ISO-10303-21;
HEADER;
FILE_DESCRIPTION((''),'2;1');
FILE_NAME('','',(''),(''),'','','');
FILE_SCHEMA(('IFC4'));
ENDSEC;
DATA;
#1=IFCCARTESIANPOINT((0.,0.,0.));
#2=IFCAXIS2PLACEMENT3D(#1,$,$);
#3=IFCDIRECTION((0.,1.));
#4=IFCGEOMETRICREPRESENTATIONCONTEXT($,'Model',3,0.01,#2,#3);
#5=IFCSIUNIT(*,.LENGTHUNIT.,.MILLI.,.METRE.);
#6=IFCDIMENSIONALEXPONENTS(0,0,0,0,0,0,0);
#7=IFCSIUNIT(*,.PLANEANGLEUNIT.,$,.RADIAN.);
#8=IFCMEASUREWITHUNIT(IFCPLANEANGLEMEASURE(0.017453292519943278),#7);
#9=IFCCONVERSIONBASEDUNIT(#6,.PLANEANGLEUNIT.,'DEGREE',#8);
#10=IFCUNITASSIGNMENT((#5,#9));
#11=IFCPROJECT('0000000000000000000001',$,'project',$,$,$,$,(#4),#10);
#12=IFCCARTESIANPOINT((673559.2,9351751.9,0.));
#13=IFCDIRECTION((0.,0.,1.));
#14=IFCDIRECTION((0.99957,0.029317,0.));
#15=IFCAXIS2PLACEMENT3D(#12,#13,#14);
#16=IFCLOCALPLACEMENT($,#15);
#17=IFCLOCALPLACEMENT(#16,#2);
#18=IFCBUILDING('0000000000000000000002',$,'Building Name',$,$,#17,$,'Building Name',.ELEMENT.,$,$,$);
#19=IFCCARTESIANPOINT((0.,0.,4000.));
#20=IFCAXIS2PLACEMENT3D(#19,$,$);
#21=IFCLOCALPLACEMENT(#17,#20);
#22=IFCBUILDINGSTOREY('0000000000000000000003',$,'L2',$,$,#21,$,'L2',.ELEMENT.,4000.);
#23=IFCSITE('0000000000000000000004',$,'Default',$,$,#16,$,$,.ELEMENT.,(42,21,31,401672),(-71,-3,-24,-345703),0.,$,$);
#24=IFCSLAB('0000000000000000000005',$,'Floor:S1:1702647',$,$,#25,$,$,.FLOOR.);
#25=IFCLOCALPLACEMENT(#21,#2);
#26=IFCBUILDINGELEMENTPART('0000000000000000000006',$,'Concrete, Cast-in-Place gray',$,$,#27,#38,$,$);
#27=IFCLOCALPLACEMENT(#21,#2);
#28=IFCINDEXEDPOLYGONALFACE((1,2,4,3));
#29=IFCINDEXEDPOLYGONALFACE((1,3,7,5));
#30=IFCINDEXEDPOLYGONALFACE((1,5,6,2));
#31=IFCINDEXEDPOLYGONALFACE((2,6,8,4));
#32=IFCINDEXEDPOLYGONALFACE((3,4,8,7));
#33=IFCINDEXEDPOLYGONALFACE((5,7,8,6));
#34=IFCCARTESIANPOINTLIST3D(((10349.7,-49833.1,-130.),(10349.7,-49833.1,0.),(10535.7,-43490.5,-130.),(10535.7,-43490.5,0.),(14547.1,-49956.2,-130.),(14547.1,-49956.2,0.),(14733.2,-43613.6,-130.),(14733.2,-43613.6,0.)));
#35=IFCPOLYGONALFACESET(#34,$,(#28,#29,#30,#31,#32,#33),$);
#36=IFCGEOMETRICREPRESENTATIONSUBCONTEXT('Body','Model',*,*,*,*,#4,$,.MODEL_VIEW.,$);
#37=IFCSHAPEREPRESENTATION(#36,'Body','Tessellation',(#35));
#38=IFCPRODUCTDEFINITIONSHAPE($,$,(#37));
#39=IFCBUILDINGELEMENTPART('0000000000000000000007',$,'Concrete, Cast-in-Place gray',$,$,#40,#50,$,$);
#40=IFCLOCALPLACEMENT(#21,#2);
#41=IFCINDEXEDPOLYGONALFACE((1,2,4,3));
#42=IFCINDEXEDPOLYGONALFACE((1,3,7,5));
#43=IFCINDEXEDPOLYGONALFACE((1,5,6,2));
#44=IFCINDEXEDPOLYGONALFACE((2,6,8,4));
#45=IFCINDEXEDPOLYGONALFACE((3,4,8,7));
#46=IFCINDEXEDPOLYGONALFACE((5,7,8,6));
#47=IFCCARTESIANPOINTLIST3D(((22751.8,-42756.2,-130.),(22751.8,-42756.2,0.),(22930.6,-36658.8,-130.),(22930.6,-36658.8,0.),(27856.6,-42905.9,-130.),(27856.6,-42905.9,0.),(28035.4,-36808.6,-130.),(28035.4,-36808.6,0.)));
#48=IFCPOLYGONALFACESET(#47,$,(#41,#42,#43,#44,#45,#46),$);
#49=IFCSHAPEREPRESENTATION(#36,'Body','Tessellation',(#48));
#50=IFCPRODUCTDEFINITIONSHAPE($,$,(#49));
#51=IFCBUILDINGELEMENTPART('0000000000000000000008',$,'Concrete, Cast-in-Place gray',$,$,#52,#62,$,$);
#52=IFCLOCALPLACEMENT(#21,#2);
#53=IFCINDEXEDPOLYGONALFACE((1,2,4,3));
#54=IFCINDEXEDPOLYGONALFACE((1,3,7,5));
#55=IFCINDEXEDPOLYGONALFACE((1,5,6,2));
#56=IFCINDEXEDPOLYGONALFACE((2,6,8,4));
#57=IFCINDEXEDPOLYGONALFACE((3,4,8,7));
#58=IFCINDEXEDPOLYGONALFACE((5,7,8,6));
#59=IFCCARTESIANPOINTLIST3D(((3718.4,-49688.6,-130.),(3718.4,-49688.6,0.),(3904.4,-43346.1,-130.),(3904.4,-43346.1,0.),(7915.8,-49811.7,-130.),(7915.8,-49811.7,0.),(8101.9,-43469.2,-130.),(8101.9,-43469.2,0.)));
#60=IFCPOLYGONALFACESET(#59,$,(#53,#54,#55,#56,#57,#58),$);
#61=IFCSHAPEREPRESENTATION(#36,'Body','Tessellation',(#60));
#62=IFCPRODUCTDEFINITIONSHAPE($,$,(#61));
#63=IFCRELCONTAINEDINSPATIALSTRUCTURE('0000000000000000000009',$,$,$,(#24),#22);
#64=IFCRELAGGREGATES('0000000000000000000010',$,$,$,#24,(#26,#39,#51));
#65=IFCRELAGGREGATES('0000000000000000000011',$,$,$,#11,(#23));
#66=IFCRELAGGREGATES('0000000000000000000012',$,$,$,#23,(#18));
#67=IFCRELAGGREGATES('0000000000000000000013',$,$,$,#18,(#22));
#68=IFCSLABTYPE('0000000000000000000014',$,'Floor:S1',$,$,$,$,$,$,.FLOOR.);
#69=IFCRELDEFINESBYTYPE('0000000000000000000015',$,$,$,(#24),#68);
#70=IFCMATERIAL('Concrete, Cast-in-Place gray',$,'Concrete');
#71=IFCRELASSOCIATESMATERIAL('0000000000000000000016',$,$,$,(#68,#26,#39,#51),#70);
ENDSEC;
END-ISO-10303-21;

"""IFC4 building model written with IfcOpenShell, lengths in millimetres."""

from ifc_helpers import new_model, entity, si_unit, converted_unit, direction, frame, origin, place, context, subcontext, project, spatial, indexed_curve, outline, extrude, material, type_object, element, aggregate, save


model = new_model("IFC4")

# Units and contexts
model_context = context("Model", 3, precision=0.01, world=origin(), true_north=direction((0.0, 1.0)))
body_context = subcontext(model_context, "Body", "Model", "MODEL_VIEW")
ifc_project = project(units=[si_unit("LENGTHUNIT", "METRE", prefix="MILLI"), converted_unit("PLANEANGLEUNIT", "DEGREE", entity("IfcPlaneAngleMeasure", 0.017453292519943278), si_unit("PLANEANGLEUNIT", "RADIAN"), dimensions=[0, 0, 0, 0, 0, 0, 0])], contexts=[model_context])

# Site, building, storey
site_placement = place(None, frame((673559.2, 9351751.9, 0.0), z_axis=(0.0, 0.0, 1.0), x_axis=(0.99957, 0.029317, 0.0)))
site = spatial("IfcSite", under=ifc_project, at=site_placement, Name="Default", CompositionType="ELEMENT", RefLatitude=(42, 21, 31, 401672), RefLongitude=(-71, -3, -24, -345703), RefElevation=0.0)
building_placement = place(site_placement, origin())
building = spatial("IfcBuilding", under=site, at=building_placement, Name="Building Name", LongName="Building Name", CompositionType="ELEMENT")
storey_placement = place(building_placement, frame((0.0, 0.0, 4000.0)))
storey = spatial("IfcBuildingStorey", under=building, at=storey_placement, Name="L2", LongName="L2", CompositionType="ELEMENT", Elevation=4000.0)

# Shared definitions
ifc_material = material(Name="Concrete, Cast-in-Place gray", Category="Concrete")
slab_type_1 = type_object("IfcSlabType", Name="Floor:S1", PredefinedType="FLOOR", material=ifc_material)

# Slab, building element parts
slab_1_placement = place(storey_placement, origin())
slab_1 = element("IfcSlab", 1, at=slab_1_placement, inside=storey, type_object=slab_type_1, Name="Floor:S1:1702647", PredefinedType="FLOOR")
building_element_part_1_placement = place(slab_1_placement, origin())
building_element_part_1 = element("IfcBuildingElementPart", 2, at=building_element_part_1_placement, material=ifc_material, Name="Concrete, Cast-in-Place gray", context=body_context, shape_type="SweptSolid", body=[
    extrude(outline(indexed_curve([(-3172.6, -2099.6), (3172.6, -2099.6), (3172.6, 2099.6), (-3172.6, 2099.6), (-3172.6, -2099.6)], self_intersect=False)), frame((12541.4, -46723.4, -130.0), z_axis=(0.0, 0.0, 1.0), x_axis=(0.029317, 0.99957, 0.0)), (0.0, 0.0, 1.0), 130.0),
])
building_element_part_2_placement = place(slab_1_placement, origin())
building_element_part_2 = element("IfcBuildingElementPart", 3, at=building_element_part_2_placement, material=ifc_material, Name="Concrete, Cast-in-Place gray", context=body_context, shape_type="SweptSolid", body=[
    extrude(outline(indexed_curve([(-2553.5, -3050.0), (2553.5, -3050.0), (2553.5, 3050.0), (-2553.5, 3050.0), (-2553.5, -3050.0)], self_intersect=False)), frame((25393.6, -39782.4, -130.0), z_axis=(0.0, 0.0, 1.0), x_axis=(-0.99957, 0.029317, 0.0)), (0.0, 0.0, 1.0), 130.0),
])
building_element_part_3_placement = place(slab_1_placement, origin())
building_element_part_3 = element("IfcBuildingElementPart", 4, at=building_element_part_3_placement, material=ifc_material, Name="Concrete, Cast-in-Place gray", context=body_context, shape_type="SweptSolid", body=[
    extrude(outline(indexed_curve([(-3172.6, -2099.6), (3172.6, -2099.6), (3172.6, 2099.6), (-3172.6, 2099.6), (-3172.6, -2099.6)], self_intersect=False)), frame((5910.1, -46578.9, -130.0), z_axis=(0.0, 0.0, 1.0), x_axis=(0.029317, 0.99957, 0.0)), (0.0, 0.0, 1.0), 130.0),
])
aggregate(slab_1, [building_element_part_1, building_element_part_2, building_element_part_3])

save(model, "model.ifc")
